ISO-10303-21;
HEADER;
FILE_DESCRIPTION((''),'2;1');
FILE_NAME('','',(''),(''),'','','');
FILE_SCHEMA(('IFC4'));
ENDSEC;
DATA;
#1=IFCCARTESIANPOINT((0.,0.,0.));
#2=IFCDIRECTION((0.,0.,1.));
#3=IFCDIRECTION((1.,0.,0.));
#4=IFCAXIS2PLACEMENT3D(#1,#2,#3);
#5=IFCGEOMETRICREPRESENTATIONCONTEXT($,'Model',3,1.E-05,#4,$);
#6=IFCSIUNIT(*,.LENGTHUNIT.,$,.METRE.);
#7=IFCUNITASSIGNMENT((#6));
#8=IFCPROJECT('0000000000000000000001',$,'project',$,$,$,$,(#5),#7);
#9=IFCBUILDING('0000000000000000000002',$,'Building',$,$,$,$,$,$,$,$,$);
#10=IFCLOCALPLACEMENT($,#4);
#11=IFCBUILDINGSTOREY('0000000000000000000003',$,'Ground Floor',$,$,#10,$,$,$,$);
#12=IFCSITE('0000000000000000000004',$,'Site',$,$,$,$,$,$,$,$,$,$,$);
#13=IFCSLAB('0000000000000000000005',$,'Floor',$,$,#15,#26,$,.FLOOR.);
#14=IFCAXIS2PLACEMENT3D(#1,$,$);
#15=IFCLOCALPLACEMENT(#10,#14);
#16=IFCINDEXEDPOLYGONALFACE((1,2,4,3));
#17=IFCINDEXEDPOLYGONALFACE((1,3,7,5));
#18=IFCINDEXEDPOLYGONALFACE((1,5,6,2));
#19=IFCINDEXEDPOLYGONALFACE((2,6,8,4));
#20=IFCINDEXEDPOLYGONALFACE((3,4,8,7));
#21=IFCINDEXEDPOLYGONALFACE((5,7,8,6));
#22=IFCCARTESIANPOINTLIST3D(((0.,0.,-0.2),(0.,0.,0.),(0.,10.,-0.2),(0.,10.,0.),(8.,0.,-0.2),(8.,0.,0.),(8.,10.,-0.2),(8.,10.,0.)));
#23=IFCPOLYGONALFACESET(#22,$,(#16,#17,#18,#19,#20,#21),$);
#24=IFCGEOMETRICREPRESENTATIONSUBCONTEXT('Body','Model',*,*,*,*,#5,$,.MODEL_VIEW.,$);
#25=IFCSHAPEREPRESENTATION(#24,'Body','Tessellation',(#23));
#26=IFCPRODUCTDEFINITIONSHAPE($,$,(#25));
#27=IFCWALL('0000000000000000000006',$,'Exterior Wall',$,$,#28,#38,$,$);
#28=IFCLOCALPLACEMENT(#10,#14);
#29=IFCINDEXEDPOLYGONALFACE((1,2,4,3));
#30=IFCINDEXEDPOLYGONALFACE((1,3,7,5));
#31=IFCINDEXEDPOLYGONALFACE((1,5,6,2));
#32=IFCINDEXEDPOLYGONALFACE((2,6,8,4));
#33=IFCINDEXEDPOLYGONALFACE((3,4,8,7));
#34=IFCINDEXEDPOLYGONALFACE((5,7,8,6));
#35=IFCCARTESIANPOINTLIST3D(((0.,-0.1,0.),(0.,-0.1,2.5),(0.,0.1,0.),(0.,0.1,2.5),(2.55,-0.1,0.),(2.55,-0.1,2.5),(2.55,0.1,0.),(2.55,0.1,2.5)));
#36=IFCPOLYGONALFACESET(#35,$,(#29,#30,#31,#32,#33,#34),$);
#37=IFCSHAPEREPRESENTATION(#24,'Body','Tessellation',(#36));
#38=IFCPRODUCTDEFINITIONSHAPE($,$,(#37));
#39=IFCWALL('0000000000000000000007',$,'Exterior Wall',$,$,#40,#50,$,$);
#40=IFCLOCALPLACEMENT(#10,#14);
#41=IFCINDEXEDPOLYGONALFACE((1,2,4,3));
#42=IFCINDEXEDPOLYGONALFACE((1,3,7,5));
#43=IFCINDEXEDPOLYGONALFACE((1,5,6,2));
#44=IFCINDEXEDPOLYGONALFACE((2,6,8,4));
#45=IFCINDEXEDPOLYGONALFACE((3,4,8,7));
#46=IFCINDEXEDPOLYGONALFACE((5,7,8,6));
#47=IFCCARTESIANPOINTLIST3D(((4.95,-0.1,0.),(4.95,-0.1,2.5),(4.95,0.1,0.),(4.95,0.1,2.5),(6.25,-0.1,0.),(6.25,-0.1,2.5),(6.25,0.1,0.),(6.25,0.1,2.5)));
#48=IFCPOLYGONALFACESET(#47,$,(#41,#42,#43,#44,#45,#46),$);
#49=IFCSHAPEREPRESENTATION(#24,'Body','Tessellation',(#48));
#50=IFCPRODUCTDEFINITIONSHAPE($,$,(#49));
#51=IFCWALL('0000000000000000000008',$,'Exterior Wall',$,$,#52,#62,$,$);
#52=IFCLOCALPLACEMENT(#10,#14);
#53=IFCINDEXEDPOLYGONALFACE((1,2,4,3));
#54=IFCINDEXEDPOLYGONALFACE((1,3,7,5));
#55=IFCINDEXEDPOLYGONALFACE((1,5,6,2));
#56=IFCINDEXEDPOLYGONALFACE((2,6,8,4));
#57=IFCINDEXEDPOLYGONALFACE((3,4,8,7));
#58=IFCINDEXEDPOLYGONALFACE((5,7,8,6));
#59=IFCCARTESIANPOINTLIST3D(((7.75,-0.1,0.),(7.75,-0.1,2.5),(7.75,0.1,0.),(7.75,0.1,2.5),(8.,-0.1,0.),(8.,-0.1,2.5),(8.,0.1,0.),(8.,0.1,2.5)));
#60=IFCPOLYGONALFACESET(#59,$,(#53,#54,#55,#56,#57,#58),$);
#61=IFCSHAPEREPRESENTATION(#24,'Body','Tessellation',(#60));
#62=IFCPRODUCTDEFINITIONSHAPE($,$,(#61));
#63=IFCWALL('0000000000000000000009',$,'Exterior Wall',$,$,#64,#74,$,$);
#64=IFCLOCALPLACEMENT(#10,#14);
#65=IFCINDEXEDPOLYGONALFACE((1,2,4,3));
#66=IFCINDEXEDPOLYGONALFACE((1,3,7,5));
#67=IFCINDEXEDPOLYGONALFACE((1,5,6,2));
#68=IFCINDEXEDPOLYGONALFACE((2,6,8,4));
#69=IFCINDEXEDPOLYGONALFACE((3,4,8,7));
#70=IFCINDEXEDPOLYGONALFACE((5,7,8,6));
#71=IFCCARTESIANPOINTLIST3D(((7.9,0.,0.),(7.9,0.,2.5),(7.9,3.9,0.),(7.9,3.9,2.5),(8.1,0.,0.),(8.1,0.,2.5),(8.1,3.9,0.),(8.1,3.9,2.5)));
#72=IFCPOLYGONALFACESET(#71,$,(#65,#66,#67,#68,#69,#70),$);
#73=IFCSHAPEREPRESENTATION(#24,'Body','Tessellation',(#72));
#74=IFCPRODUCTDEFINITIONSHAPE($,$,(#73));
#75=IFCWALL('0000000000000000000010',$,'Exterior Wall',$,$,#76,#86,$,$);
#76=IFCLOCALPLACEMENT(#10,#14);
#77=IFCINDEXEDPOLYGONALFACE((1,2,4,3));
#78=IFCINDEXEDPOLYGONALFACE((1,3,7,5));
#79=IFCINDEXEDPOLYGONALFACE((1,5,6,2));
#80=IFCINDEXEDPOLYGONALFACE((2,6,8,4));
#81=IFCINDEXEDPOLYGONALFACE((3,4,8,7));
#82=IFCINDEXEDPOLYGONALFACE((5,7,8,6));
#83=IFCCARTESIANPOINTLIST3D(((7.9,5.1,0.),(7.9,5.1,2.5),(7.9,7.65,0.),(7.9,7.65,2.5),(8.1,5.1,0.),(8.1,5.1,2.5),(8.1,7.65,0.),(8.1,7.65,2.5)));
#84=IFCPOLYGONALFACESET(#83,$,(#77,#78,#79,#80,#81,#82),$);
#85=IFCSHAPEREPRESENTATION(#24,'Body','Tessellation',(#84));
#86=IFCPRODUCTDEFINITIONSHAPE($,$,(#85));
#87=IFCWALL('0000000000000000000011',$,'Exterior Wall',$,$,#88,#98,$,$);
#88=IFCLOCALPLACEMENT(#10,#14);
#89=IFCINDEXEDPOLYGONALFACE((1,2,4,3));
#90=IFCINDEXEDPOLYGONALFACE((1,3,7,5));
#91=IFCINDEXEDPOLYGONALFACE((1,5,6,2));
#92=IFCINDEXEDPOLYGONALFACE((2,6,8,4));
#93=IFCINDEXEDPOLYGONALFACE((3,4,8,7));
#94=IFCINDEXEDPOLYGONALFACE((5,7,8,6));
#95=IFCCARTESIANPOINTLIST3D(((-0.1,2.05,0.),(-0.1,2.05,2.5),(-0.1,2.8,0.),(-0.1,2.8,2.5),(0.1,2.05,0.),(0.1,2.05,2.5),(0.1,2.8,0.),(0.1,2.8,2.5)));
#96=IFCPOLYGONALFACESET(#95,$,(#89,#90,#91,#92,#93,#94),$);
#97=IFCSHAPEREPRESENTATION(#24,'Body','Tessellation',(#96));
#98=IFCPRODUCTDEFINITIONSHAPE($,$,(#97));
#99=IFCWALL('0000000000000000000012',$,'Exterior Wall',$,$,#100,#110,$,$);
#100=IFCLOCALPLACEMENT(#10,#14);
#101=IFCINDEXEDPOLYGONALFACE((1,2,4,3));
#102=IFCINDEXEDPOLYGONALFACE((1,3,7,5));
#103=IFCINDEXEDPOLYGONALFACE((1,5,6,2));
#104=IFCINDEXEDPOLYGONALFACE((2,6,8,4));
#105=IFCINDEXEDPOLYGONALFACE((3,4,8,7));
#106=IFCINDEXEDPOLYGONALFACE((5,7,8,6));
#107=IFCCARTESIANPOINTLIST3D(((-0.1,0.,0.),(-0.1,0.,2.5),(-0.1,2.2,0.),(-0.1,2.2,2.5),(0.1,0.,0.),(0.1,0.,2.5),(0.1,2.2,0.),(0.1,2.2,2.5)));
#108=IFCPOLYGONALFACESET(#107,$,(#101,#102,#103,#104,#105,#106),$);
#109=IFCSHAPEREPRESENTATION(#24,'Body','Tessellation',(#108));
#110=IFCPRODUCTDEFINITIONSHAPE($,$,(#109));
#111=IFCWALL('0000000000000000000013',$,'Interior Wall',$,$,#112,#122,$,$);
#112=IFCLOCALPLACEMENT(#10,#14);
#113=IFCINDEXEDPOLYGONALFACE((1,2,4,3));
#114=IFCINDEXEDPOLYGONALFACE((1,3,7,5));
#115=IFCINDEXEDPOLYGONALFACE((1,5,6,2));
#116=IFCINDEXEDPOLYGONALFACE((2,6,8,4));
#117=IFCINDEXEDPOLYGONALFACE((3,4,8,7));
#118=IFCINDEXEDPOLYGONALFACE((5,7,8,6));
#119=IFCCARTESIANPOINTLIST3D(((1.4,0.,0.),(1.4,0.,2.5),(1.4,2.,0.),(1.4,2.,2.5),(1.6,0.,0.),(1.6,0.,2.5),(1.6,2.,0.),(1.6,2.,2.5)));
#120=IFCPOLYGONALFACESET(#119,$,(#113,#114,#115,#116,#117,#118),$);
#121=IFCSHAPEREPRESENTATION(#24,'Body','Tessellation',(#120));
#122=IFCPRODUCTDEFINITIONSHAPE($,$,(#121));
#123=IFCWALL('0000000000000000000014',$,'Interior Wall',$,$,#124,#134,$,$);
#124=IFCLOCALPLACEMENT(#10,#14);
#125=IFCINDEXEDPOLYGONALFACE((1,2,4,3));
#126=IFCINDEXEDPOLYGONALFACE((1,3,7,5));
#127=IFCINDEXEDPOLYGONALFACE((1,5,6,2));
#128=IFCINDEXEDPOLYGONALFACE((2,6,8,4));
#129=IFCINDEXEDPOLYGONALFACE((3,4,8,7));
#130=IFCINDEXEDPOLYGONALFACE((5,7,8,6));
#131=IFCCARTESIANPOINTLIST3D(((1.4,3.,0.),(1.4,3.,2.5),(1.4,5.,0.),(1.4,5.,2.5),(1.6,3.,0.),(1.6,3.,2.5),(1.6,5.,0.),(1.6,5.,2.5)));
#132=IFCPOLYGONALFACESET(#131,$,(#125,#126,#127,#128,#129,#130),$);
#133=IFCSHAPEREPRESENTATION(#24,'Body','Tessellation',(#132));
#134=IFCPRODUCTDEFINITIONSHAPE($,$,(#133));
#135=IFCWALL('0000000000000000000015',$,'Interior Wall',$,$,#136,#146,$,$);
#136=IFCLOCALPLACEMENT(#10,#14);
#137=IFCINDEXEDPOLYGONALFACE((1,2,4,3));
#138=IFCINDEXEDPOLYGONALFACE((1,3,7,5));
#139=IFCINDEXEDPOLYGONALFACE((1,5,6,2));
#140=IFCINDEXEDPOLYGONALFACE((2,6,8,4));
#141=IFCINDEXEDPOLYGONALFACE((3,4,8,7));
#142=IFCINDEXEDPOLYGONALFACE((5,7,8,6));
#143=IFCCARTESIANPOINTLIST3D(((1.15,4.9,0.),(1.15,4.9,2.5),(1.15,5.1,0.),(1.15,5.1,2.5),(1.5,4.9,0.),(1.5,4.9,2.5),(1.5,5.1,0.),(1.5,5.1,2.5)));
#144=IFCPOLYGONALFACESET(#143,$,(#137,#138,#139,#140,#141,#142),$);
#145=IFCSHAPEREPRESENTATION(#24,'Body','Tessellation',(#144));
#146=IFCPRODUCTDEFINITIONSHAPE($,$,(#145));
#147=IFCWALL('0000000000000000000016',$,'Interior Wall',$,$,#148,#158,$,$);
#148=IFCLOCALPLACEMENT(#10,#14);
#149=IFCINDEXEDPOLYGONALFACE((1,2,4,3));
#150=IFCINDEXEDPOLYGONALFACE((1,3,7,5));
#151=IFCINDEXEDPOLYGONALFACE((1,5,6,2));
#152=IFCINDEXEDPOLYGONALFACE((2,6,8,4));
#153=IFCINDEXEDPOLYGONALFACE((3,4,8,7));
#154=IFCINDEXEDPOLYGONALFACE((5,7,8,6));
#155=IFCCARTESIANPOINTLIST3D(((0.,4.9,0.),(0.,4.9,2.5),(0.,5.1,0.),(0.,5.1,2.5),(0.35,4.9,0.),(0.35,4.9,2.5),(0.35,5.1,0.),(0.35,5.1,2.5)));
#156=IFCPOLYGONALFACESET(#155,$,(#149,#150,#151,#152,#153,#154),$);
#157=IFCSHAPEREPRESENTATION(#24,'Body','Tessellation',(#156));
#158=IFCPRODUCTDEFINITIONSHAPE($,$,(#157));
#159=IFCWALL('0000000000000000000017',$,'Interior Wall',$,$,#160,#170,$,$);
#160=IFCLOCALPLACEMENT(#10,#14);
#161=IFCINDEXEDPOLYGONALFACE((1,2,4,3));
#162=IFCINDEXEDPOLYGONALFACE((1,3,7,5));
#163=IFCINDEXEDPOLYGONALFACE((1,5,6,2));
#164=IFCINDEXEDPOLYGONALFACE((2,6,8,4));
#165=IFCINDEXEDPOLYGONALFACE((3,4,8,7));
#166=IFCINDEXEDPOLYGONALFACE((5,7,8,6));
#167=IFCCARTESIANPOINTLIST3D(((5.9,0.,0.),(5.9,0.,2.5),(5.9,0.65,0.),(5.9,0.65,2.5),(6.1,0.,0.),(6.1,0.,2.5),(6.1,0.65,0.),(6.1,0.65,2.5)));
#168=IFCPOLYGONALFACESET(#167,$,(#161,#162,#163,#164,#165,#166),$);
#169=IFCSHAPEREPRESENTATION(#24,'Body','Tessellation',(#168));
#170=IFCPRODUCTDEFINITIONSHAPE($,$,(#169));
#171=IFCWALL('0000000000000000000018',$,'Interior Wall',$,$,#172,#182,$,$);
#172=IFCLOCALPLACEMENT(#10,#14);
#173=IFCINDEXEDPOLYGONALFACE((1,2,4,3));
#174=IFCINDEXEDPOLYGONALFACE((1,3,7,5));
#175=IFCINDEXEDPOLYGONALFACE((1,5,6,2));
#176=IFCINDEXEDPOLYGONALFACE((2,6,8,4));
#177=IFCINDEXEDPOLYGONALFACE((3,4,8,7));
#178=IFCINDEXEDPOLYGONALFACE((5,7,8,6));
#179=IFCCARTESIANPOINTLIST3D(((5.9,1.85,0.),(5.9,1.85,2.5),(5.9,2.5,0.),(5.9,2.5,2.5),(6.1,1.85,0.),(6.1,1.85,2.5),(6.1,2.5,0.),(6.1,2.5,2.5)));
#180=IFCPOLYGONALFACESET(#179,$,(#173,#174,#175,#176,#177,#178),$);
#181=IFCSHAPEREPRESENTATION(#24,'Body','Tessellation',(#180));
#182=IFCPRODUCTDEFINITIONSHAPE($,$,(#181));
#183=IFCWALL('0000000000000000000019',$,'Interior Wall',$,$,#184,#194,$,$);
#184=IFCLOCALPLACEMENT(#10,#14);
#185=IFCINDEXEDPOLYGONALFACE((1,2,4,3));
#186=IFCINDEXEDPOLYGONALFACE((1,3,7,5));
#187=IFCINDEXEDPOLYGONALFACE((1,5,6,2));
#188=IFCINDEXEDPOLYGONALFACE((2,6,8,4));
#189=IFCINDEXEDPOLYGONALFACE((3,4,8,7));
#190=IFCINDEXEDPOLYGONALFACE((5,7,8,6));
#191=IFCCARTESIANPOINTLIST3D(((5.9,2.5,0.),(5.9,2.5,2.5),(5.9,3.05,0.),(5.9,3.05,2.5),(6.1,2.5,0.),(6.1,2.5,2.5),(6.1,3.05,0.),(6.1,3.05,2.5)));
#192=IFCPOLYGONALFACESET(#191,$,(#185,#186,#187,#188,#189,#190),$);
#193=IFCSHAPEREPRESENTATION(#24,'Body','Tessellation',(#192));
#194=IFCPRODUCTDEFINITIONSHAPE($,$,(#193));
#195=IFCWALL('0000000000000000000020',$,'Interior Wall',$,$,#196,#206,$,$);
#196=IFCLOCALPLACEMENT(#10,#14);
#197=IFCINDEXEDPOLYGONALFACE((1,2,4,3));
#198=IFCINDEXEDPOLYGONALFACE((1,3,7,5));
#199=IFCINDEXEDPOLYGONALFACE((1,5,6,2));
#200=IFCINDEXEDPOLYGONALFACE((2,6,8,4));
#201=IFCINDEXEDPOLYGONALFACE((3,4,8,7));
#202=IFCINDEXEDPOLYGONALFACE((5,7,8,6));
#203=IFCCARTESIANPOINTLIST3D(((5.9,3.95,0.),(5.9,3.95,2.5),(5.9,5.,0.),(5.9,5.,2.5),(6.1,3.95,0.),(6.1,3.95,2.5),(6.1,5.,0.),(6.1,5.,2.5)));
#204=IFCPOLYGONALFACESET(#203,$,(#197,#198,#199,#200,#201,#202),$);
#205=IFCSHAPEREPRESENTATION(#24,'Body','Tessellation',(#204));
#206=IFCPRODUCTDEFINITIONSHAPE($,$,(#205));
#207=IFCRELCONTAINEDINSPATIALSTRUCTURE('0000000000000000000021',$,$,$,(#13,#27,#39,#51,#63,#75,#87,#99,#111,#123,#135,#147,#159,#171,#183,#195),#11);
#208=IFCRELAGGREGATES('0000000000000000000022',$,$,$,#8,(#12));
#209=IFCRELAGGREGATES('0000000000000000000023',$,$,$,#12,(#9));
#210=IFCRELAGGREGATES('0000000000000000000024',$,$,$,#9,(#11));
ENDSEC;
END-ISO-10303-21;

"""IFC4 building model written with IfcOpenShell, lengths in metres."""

from ifc_helpers import new_model, si_unit, frame, origin_with_axes, place, context, subcontext, project, spatial, indexed_curve, outline, extrude, element, save


model = new_model("IFC4")

# Units and contexts
model_context = context("Model", 3, precision=1e-05, world=origin_with_axes())
body_context = subcontext(model_context, "Body", "Model", "MODEL_VIEW")
ifc_project = project(units=[si_unit("LENGTHUNIT", "METRE")], contexts=[model_context])

# Site, building, storey
site = spatial("IfcSite", under=ifc_project, Name="Site")
building = spatial("IfcBuilding", under=site, Name="Building")
storey_placement = place(None, origin_with_axes())
storey = spatial("IfcBuildingStorey", under=building, at=storey_placement, Name="Ground Floor")

# Slab
slab_placement = place(storey_placement, frame((0.0, 0.0, -0.2), z_axis=(0.0, 0.0, 1.0), x_axis=(1.0, 0.0, 0.0)))
element("IfcSlab", 1, at=slab_placement, inside=storey, Name="Floor", PredefinedType="FLOOR", context=body_context, shape_type="SweptSolid", body=[
    extrude(outline(indexed_curve([(0.0, 0.0), (8.0, 0.0), (8.0, 10.0), (0.0, 10.0)])), None, (0.0, 0.0, 1.0), 0.2),
])

# Walls
wall_1_placement = place(storey_placement, origin_with_axes())
element("IfcWall", 2, at=wall_1_placement, inside=storey, Name="Exterior Wall", context=body_context, shape_type="SweptSolid", body=[
    extrude(outline(indexed_curve([(0.0, 0.0), (0.0, 0.2), (2.55, 0.2), (2.55, 0.0), (0.0, 0.0)], self_intersect=False)), frame((0.0, -0.1, 0.0), z_axis=(0.0, 0.0, 1.0), x_axis=(1.0, 0.0, 0.0)), (0.0, 0.0, 1.0), 2.5),
])
wall_2_placement = place(storey_placement, frame((4.95, 0.0, 0.0), z_axis=(0.0, 0.0, 1.0), x_axis=(1.0, 0.0, 0.0)))
element("IfcWall", 3, at=wall_2_placement, inside=storey, Name="Exterior Wall", context=body_context, shape_type="SweptSolid", body=[
    extrude(outline(indexed_curve([(0.0, 0.0), (0.0, 0.2), (1.3, 0.2), (1.3, 0.0), (0.0, 0.0)], self_intersect=False)), frame((0.0, -0.1, 0.0), z_axis=(0.0, 0.0, 1.0), x_axis=(1.0, 0.0, 0.0)), (0.0, 0.0, 1.0), 2.5),
])
wall_3_placement = place(storey_placement, frame((7.75, 0.0, 0.0), z_axis=(0.0, 0.0, 1.0), x_axis=(1.0, 0.0, 0.0)))
element("IfcWall", 4, at=wall_3_placement, inside=storey, Name="Exterior Wall", context=body_context, shape_type="SweptSolid", body=[
    extrude(outline(indexed_curve([(0.0, 0.0), (0.0, 0.2), (0.25, 0.2), (0.25, 0.0), (0.0, 0.0)], self_intersect=False)), frame((0.0, -0.1, 0.0), z_axis=(0.0, 0.0, 1.0), x_axis=(1.0, 0.0, 0.0)), (0.0, 0.0, 1.0), 2.5),
])
wall_4_placement = place(storey_placement, frame((8.0, 0.0, 0.0), z_axis=(0.0, 0.0, 1.0), x_axis=(0.0, 1.0, 0.0)))
element("IfcWall", 5, at=wall_4_placement, inside=storey, Name="Exterior Wall", context=body_context, shape_type="SweptSolid", body=[
    extrude(outline(indexed_curve([(0.0, 0.0), (0.0, 0.2), (3.9, 0.2), (3.9, 0.0), (0.0, 0.0)], self_intersect=False)), frame((0.0, -0.1, 0.0), z_axis=(0.0, 0.0, 1.0), x_axis=(1.0, 0.0, 0.0)), (0.0, 0.0, 1.0), 2.5),
])
wall_5_placement = place(storey_placement, frame((8.0, 5.1, 0.0), z_axis=(0.0, 0.0, 1.0), x_axis=(0.0, 1.0, 0.0)))
element("IfcWall", 6, at=wall_5_placement, inside=storey, Name="Exterior Wall", context=body_context, shape_type="SweptSolid", body=[
    extrude(outline(indexed_curve([(0.0, 0.0), (0.0, 0.2), (2.55, 0.2), (2.55, 0.0), (0.0, 0.0)], self_intersect=False)), frame((0.0, -0.1, 0.0), z_axis=(0.0, 0.0, 1.0), x_axis=(1.0, 0.0, 0.0)), (0.0, 0.0, 1.0), 2.5),
])
wall_6_placement = place(storey_placement, frame((0.0, 2.05, 0.0), z_axis=(0.0, 0.0, 1.0), x_axis=(0.0, 1.0, 0.0)))
element("IfcWall", 7, at=wall_6_placement, inside=storey, Name="Exterior Wall", context=body_context, shape_type="SweptSolid", body=[
    extrude(outline(indexed_curve([(0.0, 0.0), (0.0, 0.2), (0.75, 0.2), (0.75, 0.0), (0.0, 0.0)], self_intersect=False)), frame((0.0, -0.1, 0.0), z_axis=(0.0, 0.0, 1.0), x_axis=(1.0, 0.0, 0.0)), (0.0, 0.0, 1.0), 2.5),
])
wall_7_placement = place(storey_placement, frame((0.0, 2.2, 0.0), z_axis=(0.0, 0.0, 1.0), x_axis=(0.0, -1.0, 0.0)))
element("IfcWall", 8, at=wall_7_placement, inside=storey, Name="Exterior Wall", context=body_context, shape_type="SweptSolid", body=[
    extrude(outline(indexed_curve([(0.0, 0.0), (0.0, 0.2), (2.2, 0.2), (2.2, 0.0), (0.0, 0.0)], self_intersect=False)), frame((0.0, -0.1, 0.0), z_axis=(0.0, 0.0, 1.0), x_axis=(1.0, 0.0, 0.0)), (0.0, 0.0, 1.0), 2.5),
])
for number, where, z_axis, x_axis, name in (
    (9, (1.5, 0.0, 0.0), (0.0, 0.0, 1.0), (0.0, 1.0, 0.0), "Interior Wall"),
    (10, (1.5, 3.0, 0.0), (0.0, 0.0, 1.0), (0.0, 1.0, 0.0), "Interior Wall"),
):
    element("IfcWall", number, at=place(storey_placement, frame(where, z_axis=z_axis, x_axis=x_axis)), inside=storey, Name=name, context=body_context, shape_type="SweptSolid", body=[
        extrude(outline(indexed_curve([(0.0, 0.0), (0.0, 0.2), (2.0, 0.2), (2.0, 0.0), (0.0, 0.0)], self_intersect=False)), frame((0.0, -0.1, 0.0), z_axis=(0.0, 0.0, 1.0), x_axis=(1.0, 0.0, 0.0)), (0.0, 0.0, 1.0), 2.5),
    ])
for number, where, z_axis, x_axis, name in (
    (11, (1.5, 5.0, 0.0), (0.0, 0.0, 1.0), (-1.0, 0.0, 0.0), "Interior Wall"),
    (12, (0.35, 5.0, 0.0), (0.0, 0.0, 1.0), (-1.0, 0.0, 0.0), "Interior Wall"),
):
    element("IfcWall", number, at=place(storey_placement, frame(where, z_axis=z_axis, x_axis=x_axis)), inside=storey, Name=name, context=body_context, shape_type="SweptSolid", body=[
        extrude(outline(indexed_curve([(0.0, 0.0), (0.0, 0.2), (0.35, 0.2), (0.35, 0.0), (0.0, 0.0)], self_intersect=False)), frame((0.0, -0.1, 0.0), z_axis=(0.0, 0.0, 1.0), x_axis=(1.0, 0.0, 0.0)), (0.0, 0.0, 1.0), 2.5),
    ])
wall_8_placement = place(storey_placement, frame((6.0, 0.0, 0.0), z_axis=(0.0, 0.0, 1.0), x_axis=(0.0, 1.0, 0.0)))
element("IfcWall", 13, at=wall_8_placement, inside=storey, Name="Interior Wall", context=body_context, shape_type="SweptSolid", body=[
    extrude(outline(indexed_curve([(0.0, 0.0), (0.0, 0.2), (0.65, 0.2), (0.65, 0.0), (0.0, 0.0)], self_intersect=False)), frame((0.0, -0.1, 0.0), z_axis=(0.0, 0.0, 1.0), x_axis=(1.0, 0.0, 0.0)), (0.0, 0.0, 1.0), 2.5),
])
wall_9_placement = place(storey_placement, frame((6.0, 1.85, 0.0), z_axis=(0.0, 0.0, 1.0), x_axis=(0.0, 1.0, 0.0)))
element("IfcWall", 14, at=wall_9_placement, inside=storey, Name="Interior Wall", context=body_context, shape_type="SweptSolid", body=[
    extrude(outline(indexed_curve([(0.0, 0.0), (0.0, 0.2), (0.65, 0.2), (0.65, 0.0), (0.0, 0.0)], self_intersect=False)), frame((0.0, -0.1, 0.0), z_axis=(0.0, 0.0, 1.0), x_axis=(1.0, 0.0, 0.0)), (0.0, 0.0, 1.0), 2.5),
])
wall_10_placement = place(storey_placement, frame((6.0, 2.5, 0.0), z_axis=(0.0, 0.0, 1.0), x_axis=(0.0, 1.0, 0.0)))
element("IfcWall", 15, at=wall_10_placement, inside=storey, Name="Interior Wall", context=body_context, shape_type="SweptSolid", body=[
    extrude(outline(indexed_curve([(0.0, 0.0), (0.0, 0.2), (0.55, 0.2), (0.55, 0.0), (0.0, 0.0)], self_intersect=False)), frame((0.0, -0.1, 0.0), z_axis=(0.0, 0.0, 1.0), x_axis=(1.0, 0.0, 0.0)), (0.0, 0.0, 1.0), 2.5),
])
wall_11_placement = place(storey_placement, frame((6.0, 3.95, 0.0), z_axis=(0.0, 0.0, 1.0), x_axis=(0.0, 1.0, 0.0)))
element("IfcWall", 16, at=wall_11_placement, inside=storey, Name="Interior Wall", context=body_context, shape_type="SweptSolid", body=[
    extrude(outline(indexed_curve([(0.0, 0.0), (0.0, 0.2), (1.05, 0.2), (1.05, 0.0), (0.0, 0.0)], self_intersect=False)), frame((0.0, -0.1, 0.0), z_axis=(0.0, 0.0, 1.0), x_axis=(1.0, 0.0, 0.0)), (0.0, 0.0, 1.0), 2.5),
])

save(model, "model.ifc")
